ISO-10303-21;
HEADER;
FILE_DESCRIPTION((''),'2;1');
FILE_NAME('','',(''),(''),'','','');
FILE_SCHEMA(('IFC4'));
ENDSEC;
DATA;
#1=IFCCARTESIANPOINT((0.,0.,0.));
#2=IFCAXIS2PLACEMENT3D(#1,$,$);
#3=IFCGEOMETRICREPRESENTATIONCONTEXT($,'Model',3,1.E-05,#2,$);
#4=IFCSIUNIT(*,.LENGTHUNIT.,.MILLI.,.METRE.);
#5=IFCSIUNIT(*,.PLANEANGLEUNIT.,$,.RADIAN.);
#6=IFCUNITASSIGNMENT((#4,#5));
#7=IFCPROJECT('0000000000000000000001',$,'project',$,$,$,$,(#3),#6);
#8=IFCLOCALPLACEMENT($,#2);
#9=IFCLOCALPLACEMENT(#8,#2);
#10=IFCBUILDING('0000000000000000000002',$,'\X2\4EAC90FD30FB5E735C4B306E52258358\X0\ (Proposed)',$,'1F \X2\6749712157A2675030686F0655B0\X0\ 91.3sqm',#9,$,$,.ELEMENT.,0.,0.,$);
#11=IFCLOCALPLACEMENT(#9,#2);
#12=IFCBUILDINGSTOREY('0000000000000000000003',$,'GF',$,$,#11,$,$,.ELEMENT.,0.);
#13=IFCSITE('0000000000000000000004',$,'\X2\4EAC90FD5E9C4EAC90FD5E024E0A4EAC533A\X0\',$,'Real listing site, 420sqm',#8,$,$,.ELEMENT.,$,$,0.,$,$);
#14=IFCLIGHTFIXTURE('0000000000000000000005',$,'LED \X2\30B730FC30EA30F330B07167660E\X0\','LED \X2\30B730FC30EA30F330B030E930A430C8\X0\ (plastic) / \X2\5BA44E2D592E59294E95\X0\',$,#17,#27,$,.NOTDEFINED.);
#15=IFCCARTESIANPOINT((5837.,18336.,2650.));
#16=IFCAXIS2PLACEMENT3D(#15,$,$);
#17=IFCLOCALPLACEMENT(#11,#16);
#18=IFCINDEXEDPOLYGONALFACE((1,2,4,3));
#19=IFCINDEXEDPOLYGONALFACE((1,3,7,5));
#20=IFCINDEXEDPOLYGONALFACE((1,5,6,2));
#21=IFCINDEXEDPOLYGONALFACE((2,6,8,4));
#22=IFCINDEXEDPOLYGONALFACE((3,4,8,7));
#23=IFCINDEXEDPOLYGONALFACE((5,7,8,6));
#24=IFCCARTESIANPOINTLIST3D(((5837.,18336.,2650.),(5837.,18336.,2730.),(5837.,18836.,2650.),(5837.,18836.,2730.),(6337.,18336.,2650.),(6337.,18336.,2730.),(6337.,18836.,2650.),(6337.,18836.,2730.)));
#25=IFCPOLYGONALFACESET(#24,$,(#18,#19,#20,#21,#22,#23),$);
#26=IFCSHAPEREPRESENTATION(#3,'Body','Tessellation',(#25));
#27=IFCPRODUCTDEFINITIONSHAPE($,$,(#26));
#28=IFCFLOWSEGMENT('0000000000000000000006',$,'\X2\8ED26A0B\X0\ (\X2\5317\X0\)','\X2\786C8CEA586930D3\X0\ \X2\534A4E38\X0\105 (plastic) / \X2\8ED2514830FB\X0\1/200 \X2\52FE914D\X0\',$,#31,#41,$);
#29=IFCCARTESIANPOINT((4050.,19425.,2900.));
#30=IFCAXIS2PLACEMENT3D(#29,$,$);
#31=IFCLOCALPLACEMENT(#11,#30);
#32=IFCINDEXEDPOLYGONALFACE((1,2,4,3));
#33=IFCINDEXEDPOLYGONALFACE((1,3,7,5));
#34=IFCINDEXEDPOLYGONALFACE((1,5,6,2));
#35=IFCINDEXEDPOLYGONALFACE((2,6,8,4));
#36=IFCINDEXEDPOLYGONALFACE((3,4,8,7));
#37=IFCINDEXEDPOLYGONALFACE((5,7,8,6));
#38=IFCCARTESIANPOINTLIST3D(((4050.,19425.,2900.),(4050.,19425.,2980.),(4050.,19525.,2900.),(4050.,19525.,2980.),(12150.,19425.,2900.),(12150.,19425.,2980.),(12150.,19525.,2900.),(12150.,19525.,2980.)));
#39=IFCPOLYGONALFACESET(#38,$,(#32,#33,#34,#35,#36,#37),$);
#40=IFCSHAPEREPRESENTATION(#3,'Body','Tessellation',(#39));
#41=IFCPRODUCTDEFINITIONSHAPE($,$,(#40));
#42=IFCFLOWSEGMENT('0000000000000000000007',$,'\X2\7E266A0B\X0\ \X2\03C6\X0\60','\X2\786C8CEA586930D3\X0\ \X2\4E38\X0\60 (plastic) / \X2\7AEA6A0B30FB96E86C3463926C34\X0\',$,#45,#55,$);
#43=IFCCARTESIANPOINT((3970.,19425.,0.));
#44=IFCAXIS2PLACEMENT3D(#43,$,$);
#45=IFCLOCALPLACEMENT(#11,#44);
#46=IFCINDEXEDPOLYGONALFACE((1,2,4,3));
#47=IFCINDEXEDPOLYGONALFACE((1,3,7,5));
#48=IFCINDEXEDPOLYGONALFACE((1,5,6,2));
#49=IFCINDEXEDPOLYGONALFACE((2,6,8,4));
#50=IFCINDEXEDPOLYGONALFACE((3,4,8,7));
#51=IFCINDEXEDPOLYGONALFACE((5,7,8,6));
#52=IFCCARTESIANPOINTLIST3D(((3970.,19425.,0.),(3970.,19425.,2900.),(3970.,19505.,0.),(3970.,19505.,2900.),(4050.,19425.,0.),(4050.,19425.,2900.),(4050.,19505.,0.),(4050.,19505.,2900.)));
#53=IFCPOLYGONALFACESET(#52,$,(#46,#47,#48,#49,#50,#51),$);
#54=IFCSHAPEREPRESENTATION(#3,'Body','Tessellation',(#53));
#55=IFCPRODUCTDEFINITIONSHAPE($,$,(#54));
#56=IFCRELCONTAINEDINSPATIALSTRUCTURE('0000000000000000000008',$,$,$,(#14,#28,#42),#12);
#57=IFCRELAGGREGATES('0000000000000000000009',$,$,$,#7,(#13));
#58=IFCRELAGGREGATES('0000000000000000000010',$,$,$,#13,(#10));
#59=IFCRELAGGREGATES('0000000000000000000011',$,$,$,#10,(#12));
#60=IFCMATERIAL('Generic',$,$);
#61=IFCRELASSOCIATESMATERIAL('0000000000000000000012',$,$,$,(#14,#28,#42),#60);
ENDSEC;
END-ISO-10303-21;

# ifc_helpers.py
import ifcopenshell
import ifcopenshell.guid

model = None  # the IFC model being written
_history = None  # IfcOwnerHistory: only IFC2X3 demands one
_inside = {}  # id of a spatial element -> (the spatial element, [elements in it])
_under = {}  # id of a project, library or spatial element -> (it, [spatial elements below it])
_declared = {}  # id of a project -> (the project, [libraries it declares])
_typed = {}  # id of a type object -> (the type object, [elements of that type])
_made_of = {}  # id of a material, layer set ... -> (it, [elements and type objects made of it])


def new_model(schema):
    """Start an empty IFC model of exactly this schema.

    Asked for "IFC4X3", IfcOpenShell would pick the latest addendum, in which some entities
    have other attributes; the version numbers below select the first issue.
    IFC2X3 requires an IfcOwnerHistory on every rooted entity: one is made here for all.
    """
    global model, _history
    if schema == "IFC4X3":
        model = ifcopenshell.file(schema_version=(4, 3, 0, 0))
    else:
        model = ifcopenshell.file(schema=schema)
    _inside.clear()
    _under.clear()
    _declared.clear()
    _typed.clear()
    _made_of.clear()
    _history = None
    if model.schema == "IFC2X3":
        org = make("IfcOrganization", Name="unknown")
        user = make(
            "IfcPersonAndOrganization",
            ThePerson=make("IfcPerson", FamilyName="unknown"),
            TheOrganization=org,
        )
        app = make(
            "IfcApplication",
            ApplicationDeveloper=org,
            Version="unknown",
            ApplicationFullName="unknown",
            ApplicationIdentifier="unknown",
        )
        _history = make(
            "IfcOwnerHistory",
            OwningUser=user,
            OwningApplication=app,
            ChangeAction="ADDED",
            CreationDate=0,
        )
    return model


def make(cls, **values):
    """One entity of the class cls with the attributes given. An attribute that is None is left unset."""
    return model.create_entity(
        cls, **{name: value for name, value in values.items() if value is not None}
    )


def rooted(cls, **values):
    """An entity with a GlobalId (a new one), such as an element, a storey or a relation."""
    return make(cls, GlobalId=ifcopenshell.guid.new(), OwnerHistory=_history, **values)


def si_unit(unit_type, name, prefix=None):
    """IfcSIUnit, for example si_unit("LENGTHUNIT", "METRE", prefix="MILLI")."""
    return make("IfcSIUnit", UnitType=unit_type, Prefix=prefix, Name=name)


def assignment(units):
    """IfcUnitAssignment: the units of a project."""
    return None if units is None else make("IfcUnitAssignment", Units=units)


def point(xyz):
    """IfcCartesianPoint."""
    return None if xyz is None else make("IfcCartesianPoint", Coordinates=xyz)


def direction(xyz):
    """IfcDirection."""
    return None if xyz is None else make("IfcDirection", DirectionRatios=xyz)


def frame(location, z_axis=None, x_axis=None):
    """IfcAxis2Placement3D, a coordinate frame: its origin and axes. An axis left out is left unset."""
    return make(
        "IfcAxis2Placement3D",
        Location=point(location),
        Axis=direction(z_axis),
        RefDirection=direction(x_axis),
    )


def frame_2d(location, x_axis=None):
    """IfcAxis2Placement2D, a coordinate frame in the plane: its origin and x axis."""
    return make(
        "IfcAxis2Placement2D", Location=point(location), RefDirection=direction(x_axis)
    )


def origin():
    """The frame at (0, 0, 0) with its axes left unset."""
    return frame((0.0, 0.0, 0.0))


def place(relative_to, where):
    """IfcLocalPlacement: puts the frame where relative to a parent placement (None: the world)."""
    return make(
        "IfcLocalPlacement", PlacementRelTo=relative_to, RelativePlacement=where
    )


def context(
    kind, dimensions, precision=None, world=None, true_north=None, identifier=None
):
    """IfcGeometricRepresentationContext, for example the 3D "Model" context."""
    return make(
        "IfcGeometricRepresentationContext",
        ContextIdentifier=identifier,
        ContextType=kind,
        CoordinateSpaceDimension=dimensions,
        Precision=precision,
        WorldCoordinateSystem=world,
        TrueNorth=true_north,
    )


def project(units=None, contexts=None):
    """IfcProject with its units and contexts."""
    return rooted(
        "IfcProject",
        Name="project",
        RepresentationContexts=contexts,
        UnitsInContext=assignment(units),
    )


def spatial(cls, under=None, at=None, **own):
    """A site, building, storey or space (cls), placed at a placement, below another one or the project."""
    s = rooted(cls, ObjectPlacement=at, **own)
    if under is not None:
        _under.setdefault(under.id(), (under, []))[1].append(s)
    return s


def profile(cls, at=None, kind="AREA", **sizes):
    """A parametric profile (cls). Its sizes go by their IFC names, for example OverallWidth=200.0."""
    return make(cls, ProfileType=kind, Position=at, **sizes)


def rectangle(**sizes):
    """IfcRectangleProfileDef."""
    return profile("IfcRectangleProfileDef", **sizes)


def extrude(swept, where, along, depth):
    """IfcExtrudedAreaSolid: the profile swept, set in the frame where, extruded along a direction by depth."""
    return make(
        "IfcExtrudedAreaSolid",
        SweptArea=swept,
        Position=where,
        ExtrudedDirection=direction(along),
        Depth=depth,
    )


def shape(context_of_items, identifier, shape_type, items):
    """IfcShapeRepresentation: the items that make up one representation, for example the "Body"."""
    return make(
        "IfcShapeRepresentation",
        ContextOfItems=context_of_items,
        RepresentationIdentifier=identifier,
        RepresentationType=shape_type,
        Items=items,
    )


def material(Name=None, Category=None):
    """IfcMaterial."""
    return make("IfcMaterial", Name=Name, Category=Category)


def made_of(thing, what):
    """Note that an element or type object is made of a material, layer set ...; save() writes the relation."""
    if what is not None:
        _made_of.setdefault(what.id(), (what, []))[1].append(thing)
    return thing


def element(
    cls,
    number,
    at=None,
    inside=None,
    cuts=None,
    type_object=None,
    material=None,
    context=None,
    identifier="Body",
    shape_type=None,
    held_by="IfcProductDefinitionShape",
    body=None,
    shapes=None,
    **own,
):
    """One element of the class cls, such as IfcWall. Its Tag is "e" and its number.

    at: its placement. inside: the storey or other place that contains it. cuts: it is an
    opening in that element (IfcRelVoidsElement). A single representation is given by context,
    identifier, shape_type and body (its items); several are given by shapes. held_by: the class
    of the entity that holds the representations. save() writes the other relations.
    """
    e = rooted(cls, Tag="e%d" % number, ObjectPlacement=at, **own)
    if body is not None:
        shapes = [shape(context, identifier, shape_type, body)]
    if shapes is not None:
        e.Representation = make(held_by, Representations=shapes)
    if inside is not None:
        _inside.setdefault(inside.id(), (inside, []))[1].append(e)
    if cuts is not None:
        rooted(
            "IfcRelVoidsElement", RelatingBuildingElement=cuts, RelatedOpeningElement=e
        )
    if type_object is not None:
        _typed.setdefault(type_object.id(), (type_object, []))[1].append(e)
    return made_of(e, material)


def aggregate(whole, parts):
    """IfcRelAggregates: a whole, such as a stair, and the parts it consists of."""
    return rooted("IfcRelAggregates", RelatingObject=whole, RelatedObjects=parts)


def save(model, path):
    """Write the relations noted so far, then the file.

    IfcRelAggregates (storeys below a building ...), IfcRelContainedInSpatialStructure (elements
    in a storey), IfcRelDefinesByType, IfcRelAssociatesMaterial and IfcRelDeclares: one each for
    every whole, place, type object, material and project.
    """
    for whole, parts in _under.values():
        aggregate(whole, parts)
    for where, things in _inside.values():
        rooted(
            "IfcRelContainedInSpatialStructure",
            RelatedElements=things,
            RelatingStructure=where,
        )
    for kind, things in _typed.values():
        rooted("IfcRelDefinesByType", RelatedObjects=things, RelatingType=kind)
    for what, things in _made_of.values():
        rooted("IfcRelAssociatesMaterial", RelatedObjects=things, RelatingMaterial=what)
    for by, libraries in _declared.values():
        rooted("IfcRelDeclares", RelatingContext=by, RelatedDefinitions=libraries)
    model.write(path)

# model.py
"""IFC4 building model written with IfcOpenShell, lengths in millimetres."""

from ifc_helpers import new_model, si_unit, frame, frame_2d, origin, place, context, project, spatial, rectangle, extrude, material, element, save


model = new_model("IFC4")

# Units and contexts
model_context = context("Model", 3, precision=1e-05, world=origin())
ifc_project = project(units=[si_unit("LENGTHUNIT", "METRE", prefix="MILLI"), si_unit("PLANEANGLEUNIT", "RADIAN")], contexts=[model_context])

# Site, building, storey
site_placement = place(None, origin())
site = spatial("IfcSite", under=ifc_project, at=site_placement, Name="京都府京都市上京区", ObjectType="Real listing site, 420sqm", CompositionType="ELEMENT", RefElevation=0.0)
building_placement = place(site_placement, origin())
building = spatial("IfcBuilding", under=site, at=building_placement, Name="京都・平屋の別荘 (Proposed)", ObjectType="1F 杉無垢材と漆喰 91.3sqm", CompositionType="ELEMENT", ElevationOfRefHeight=0.0, ElevationOfTerrain=0.0)
storey_placement = place(building_placement, origin())
storey = spatial("IfcBuildingStorey", under=building, at=storey_placement, Name="GF", CompositionType="ELEMENT", Elevation=0.0)

# Shared definitions
ifc_material_1 = material(Name="Generic")

# Light fixture
light_fixture_placement = place(storey_placement, frame((5837.0, 18336.0, 2650.0)))
element("IfcLightFixture", 1, at=light_fixture_placement, inside=storey, material=ifc_material_1, Name="LED シーリング照明", Description="LED シーリングライト (plastic) / 室中央天井", PredefinedType="NOTDEFINED", context=model_context, shape_type="SweptSolid", body=[
    extrude(rectangle(XDim=500.0, YDim=500.0, at=frame_2d((250.0, 250.0))), frame((5837.0, 18336.0, 2650.0)), (0.0, 0.0, 1.0), 80.0),
])

# Flow segments
flow_segment_1_placement = place(storey_placement, frame((4050.0, 19425.0, 2900.0)))
element("IfcFlowSegment", 2, at=flow_segment_1_placement, inside=storey, material=ifc_material_1, Name="軒樋 (北)", Description="硬質塩ビ 半丸105 (plastic) / 軒先・1/200 勾配", context=model_context, shape_type="SweptSolid", body=[
    extrude(rectangle(XDim=8100.0, YDim=100.0, at=frame_2d((4050.0, 50.0))), frame((4050.0, 19425.0, 2900.0)), (0.0, 0.0, 1.0), 80.0),
])
flow_segment_2_placement = place(storey_placement, frame((3970.0, 19425.0, 0.0)))
element("IfcFlowSegment", 3, at=flow_segment_2_placement, inside=storey, material=ifc_material_1, Name="縦樋 φ60", Description="硬質塩ビ 丸60 (plastic) / 竪樋・雨水排水", context=model_context, shape_type="SweptSolid", body=[
    extrude(rectangle(XDim=80.0, YDim=80.0, at=frame_2d((40.0, 40.0))), frame((3970.0, 19425.0, 0.0)), (0.0, 0.0, 1.0), 2900.0),
])

save(model, "model.ifc")
